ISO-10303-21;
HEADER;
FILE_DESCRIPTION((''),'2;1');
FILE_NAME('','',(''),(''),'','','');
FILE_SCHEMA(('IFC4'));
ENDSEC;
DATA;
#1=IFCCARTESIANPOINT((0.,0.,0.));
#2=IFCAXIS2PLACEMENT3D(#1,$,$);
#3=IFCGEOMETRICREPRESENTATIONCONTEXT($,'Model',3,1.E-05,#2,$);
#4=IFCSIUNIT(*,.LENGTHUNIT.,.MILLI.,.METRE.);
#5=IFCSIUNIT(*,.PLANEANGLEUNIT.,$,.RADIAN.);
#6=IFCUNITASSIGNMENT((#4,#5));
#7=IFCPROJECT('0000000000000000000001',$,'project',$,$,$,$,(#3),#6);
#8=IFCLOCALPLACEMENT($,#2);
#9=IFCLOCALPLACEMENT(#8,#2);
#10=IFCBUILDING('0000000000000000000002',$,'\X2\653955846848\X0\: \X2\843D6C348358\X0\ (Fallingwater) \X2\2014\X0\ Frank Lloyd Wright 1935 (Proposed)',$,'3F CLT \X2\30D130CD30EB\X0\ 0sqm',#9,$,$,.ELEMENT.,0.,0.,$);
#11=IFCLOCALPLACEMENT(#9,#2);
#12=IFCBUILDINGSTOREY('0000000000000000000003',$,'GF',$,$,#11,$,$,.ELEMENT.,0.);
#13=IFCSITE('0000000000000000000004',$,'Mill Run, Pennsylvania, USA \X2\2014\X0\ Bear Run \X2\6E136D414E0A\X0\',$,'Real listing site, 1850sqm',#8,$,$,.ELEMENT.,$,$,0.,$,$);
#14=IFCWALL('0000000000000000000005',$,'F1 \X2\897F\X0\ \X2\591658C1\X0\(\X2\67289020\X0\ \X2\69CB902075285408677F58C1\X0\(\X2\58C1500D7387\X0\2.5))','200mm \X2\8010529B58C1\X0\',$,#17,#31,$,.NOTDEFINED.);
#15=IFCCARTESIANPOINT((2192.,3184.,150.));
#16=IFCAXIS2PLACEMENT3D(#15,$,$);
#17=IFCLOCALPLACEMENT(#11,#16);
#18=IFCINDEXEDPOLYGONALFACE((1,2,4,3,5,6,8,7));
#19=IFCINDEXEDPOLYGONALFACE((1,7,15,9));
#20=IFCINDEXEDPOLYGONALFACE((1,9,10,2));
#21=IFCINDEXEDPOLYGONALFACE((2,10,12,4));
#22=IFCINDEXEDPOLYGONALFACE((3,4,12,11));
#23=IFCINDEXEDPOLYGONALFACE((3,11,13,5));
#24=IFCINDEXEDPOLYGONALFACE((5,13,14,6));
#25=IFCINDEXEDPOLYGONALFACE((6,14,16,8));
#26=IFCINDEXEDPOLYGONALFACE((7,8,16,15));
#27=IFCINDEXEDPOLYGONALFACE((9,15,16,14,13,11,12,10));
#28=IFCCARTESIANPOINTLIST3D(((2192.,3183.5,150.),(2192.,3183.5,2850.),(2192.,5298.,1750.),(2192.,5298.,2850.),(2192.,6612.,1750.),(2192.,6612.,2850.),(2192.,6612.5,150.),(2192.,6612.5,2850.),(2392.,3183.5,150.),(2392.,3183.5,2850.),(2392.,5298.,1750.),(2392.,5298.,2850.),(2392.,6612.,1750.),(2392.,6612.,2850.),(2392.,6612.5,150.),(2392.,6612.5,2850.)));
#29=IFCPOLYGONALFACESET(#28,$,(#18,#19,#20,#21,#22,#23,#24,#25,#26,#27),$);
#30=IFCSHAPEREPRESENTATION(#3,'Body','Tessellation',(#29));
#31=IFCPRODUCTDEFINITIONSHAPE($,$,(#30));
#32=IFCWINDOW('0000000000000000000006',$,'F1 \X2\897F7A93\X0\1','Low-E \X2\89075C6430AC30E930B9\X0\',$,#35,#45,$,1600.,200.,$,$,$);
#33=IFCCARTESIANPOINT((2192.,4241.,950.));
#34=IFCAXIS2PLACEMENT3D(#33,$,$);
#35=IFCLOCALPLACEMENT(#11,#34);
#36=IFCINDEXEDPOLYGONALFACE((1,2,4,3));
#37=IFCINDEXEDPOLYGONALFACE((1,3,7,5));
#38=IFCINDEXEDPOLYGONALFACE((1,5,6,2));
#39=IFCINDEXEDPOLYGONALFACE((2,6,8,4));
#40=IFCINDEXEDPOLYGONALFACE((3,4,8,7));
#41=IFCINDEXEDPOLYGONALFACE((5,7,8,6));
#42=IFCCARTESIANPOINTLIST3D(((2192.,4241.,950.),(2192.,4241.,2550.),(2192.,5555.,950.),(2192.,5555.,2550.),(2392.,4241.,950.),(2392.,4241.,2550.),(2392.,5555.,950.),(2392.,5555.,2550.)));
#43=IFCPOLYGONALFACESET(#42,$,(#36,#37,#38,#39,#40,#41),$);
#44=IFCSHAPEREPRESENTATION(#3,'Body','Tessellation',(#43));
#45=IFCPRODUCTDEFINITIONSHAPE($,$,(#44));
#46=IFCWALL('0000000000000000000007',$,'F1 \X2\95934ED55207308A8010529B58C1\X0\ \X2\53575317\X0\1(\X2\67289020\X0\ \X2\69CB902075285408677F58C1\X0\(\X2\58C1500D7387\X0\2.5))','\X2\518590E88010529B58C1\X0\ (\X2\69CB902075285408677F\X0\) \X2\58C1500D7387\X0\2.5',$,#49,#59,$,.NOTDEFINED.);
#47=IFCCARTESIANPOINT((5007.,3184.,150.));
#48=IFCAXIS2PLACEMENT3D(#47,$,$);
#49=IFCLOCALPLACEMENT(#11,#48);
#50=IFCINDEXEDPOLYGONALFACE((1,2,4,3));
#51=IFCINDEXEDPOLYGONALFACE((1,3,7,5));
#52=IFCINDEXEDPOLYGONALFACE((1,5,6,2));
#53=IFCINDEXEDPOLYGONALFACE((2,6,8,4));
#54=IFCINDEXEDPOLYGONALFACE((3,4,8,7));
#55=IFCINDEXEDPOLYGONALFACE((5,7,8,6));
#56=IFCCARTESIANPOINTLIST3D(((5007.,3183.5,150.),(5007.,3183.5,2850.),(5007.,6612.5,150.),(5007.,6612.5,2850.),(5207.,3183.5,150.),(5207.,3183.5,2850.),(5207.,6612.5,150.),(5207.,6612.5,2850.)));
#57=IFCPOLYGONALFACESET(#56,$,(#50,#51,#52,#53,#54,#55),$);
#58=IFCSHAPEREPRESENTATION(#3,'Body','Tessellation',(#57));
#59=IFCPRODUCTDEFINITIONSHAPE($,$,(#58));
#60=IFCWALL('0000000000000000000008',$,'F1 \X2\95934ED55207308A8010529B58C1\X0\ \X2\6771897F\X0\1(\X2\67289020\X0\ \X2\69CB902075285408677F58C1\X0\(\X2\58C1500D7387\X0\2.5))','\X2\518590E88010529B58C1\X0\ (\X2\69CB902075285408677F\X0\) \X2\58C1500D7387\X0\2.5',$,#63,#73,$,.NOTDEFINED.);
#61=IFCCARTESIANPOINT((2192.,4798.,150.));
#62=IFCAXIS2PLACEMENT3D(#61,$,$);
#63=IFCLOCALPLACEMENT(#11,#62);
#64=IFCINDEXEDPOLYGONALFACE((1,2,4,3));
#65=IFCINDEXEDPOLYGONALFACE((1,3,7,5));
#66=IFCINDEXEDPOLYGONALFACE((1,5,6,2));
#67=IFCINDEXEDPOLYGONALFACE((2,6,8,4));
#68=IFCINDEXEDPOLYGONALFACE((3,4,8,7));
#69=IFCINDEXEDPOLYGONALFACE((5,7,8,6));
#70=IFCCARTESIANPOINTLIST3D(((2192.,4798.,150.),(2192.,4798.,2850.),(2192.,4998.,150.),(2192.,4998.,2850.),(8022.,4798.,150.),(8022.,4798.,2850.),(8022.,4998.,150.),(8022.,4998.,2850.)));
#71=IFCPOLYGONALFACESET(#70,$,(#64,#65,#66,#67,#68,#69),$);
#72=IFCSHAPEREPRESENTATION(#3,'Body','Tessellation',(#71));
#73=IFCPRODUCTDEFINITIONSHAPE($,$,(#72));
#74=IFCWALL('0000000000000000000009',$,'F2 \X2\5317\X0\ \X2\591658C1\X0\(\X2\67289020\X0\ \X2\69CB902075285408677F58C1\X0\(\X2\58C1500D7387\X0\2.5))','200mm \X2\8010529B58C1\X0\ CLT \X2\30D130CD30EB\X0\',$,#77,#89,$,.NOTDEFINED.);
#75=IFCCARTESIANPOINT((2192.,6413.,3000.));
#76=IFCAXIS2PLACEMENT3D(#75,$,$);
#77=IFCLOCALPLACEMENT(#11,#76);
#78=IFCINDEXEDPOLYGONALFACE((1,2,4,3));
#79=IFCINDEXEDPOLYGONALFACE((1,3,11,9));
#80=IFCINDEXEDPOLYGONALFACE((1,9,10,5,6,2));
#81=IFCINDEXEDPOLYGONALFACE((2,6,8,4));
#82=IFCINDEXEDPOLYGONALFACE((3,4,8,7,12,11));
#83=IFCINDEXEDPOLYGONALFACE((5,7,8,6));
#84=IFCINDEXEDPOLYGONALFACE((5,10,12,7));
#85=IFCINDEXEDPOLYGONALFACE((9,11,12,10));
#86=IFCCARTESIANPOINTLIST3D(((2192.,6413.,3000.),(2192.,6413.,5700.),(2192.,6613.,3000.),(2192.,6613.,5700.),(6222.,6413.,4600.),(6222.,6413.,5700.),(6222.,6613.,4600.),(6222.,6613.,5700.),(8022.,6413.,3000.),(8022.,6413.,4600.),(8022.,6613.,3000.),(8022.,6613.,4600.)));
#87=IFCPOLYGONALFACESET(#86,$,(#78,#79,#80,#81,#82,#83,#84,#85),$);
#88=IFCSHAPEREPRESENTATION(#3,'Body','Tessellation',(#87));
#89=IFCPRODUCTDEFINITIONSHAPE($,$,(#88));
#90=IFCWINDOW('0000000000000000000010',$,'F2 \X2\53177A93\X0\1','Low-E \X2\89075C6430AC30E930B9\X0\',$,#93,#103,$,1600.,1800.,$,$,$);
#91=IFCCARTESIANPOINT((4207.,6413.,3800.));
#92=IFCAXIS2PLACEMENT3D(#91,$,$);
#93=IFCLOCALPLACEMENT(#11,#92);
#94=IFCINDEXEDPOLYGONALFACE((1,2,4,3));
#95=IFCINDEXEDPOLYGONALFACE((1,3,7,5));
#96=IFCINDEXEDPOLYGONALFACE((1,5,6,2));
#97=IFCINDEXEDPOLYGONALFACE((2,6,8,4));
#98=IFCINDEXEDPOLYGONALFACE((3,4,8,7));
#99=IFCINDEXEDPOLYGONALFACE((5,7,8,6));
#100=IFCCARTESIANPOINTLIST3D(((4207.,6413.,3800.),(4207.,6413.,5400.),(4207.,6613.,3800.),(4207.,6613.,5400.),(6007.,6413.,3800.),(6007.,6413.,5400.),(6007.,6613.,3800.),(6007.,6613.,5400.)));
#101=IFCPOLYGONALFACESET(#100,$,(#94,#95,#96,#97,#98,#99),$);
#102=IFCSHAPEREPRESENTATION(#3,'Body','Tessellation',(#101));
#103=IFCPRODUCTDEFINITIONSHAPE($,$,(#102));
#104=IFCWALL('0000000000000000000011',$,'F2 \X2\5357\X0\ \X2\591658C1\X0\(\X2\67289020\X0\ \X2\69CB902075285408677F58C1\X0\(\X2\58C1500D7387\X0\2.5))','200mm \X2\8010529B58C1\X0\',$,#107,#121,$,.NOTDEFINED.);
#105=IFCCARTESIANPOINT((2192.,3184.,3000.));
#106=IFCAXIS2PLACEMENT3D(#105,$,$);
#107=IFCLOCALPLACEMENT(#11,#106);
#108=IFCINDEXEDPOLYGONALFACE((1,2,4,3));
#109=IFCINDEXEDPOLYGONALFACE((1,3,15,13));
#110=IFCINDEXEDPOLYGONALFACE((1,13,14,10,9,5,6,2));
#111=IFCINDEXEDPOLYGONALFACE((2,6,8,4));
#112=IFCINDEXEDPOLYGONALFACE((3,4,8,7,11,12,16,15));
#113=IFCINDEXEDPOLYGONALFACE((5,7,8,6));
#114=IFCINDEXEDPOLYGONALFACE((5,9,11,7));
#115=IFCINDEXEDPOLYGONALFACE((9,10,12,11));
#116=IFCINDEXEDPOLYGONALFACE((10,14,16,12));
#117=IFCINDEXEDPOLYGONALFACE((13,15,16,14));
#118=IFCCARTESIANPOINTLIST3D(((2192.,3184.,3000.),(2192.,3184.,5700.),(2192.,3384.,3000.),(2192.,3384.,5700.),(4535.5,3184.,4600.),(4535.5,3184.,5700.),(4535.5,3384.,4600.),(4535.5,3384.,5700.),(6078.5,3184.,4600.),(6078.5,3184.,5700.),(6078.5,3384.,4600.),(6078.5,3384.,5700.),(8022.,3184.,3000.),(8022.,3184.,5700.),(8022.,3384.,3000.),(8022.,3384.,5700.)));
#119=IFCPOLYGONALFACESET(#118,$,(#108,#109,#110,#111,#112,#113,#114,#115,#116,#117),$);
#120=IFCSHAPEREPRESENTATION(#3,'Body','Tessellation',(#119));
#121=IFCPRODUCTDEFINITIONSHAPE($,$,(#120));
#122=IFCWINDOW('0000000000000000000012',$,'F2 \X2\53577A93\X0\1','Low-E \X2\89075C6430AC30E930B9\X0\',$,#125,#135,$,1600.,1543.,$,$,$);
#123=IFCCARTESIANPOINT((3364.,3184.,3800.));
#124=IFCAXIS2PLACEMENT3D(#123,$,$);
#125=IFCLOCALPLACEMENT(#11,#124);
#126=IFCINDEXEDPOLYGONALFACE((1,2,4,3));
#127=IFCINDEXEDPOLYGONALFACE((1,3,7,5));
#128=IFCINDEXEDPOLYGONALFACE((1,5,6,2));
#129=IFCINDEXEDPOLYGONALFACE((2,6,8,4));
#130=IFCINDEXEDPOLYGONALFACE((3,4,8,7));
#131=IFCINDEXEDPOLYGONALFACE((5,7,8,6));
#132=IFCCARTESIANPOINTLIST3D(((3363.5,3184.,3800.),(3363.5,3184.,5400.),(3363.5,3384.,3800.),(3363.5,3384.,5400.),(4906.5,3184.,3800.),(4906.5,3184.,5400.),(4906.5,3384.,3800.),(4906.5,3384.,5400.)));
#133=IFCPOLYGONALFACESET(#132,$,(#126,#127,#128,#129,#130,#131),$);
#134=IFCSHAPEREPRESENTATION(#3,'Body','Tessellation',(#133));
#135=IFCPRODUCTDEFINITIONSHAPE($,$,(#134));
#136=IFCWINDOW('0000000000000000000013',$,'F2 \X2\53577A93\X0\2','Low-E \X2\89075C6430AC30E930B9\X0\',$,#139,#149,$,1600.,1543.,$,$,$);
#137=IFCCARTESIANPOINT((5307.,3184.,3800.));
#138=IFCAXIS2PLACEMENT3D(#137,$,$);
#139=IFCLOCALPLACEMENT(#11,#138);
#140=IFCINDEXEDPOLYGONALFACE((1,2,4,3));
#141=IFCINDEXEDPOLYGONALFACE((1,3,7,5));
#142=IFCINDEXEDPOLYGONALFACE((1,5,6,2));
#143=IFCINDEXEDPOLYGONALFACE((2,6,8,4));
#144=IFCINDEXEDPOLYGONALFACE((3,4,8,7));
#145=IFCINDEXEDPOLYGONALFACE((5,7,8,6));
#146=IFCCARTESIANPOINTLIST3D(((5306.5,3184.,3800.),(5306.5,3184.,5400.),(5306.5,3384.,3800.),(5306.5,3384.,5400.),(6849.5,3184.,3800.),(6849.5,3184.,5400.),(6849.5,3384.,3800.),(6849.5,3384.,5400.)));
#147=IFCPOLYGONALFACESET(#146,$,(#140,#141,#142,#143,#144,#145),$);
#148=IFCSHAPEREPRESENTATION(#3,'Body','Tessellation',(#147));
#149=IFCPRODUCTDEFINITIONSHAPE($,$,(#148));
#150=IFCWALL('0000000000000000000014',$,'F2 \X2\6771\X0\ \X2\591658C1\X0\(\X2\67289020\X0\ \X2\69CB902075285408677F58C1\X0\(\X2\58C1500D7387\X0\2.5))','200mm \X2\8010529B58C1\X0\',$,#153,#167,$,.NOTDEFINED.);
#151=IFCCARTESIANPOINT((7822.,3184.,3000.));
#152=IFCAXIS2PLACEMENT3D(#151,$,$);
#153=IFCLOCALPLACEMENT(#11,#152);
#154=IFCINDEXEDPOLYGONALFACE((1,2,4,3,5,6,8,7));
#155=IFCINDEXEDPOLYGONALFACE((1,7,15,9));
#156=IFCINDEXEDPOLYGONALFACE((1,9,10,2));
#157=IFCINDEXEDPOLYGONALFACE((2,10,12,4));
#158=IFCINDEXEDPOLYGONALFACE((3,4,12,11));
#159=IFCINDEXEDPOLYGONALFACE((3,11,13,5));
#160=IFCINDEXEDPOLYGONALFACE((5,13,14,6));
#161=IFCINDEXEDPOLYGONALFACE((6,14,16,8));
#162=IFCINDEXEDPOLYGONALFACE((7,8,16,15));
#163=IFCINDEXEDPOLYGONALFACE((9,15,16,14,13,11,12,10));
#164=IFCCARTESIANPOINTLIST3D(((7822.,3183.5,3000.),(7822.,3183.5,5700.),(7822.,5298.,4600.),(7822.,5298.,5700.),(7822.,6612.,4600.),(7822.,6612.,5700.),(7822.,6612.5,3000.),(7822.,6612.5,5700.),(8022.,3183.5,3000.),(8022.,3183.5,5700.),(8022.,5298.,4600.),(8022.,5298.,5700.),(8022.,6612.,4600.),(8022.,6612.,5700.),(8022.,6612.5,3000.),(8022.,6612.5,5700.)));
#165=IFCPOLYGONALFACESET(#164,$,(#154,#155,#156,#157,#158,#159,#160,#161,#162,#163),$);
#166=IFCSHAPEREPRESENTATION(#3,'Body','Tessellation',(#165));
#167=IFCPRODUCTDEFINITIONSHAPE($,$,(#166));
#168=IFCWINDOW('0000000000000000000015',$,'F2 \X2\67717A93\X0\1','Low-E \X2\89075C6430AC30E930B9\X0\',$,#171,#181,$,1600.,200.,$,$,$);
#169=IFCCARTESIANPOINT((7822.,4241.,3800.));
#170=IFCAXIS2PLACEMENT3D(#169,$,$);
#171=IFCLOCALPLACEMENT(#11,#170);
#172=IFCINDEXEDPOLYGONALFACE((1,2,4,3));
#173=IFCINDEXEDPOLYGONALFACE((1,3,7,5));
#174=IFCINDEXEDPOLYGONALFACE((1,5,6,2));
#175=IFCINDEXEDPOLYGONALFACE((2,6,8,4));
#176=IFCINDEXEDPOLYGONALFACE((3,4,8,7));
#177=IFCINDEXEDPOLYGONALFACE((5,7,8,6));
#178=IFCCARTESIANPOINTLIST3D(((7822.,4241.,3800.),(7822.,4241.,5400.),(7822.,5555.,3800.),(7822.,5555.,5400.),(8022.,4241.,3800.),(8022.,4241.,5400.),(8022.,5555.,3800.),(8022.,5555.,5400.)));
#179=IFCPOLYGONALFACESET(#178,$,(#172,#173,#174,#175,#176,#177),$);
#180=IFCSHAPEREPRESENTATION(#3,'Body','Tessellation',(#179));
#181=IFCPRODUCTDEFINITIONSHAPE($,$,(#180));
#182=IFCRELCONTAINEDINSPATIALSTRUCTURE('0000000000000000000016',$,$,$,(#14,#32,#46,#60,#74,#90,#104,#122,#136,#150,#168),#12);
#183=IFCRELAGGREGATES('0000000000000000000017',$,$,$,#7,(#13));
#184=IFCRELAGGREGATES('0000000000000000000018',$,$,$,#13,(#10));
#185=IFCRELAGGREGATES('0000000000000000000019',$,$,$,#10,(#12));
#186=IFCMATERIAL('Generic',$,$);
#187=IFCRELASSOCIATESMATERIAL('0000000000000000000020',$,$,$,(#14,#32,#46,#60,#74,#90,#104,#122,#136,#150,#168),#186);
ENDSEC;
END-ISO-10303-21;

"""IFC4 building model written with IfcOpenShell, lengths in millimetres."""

from ifc_helpers import new_model, si_unit, frame, frame_2d, origin, place, context, project, spatial, rectangle, extrude, material, element, fill, save


model = new_model("IFC4")

# Units and contexts
model_context = context("Model", 3, precision=1e-05, world=origin())
ifc_project = project(units=[si_unit("LENGTHUNIT", "METRE", prefix="MILLI"), si_unit("PLANEANGLEUNIT", "RADIAN")], contexts=[model_context])

# Site, building, storey
site_placement = place(None, origin())
site = spatial("IfcSite", under=ifc_project, at=site_placement, Name="Mill Run, Pennsylvania, USA — Bear Run 渓流上", ObjectType="Real listing site, 1850sqm", CompositionType="ELEMENT", RefElevation=0.0)
building_placement = place(site_placement, origin())
building = spatial("IfcBuilding", under=site, at=building_placement, Name="改善案: 落水荘 (Fallingwater) — Frank Lloyd Wright 1935 (Proposed)", ObjectType="3F CLT パネル 0sqm", CompositionType="ELEMENT", ElevationOfRefHeight=0.0, ElevationOfTerrain=0.0)
storey_placement = place(building_placement, origin())
storey = spatial("IfcBuildingStorey", under=building, at=storey_placement, Name="GF", CompositionType="ELEMENT", Elevation=0.0)

# Shared definitions
ifc_material_1 = material(Name="Generic")

# Wall, opening, window
wall_1_placement = place(storey_placement, frame((2192.0, 3184.0, 150.0)))
wall_1 = element("IfcWall", 1, at=wall_1_placement, inside=storey, material=ifc_material_1, Name="F1 西 外壁(木造 構造用合板壁(壁倍率2.5))", Description="200mm 耐力壁", PredefinedType="NOTDEFINED", context=model_context, shape_type="SweptSolid", body=[
    extrude(rectangle(XDim=200.0, YDim=3429.0, at=frame_2d((100.0, 1714.0))), frame((2192.0, 3184.0, 150.0)), (0.0, 0.0, 1.0), 2700.0),
])
opening_1_placement = place(storey_placement, frame((2192.0, 4241.0, 950.0)))
opening_1 = element("IfcOpeningElement", 2, at=opening_1_placement, cuts=wall_1, PredefinedType="NOTDEFINED", context=model_context, shape_type="SweptSolid", body=[
    extrude(rectangle(XDim=200.0, YDim=1314.0, at=frame_2d((100.0, 657.0))), frame((2192.0, 4241.0, 950.0)), (0.0, 0.0, 1.0), 1600.0),
])
window_1_placement = place(storey_placement, frame((2192.0, 4241.0, 950.0)))
window_1 = element("IfcWindow", 3, at=window_1_placement, inside=storey, material=ifc_material_1, Name="F1 西窓1", Description="Low-E 複層ガラス", OverallHeight=1600.0, OverallWidth=200.0, context=model_context, shape_type="SweptSolid", body=[
    extrude(rectangle(XDim=200.0, YDim=1314.0, at=frame_2d((100.0, 657.0))), frame((2192.0, 4241.0, 950.0)), (0.0, 0.0, 1.0), 1600.0),
])
fill(opening_1, window_1)

# Walls
wall_2_placement = place(storey_placement, frame((5007.0, 3184.0, 150.0)))
element("IfcWall", 4, at=wall_2_placement, inside=storey, material=ifc_material_1, Name="F1 間仕切り耐力壁 南北1(木造 構造用合板壁(壁倍率2.5))", Description="内部耐力壁 (構造用合板) 壁倍率2.5", PredefinedType="NOTDEFINED", context=model_context, shape_type="SweptSolid", body=[
    extrude(rectangle(XDim=200.0, YDim=3429.0, at=frame_2d((100.0, 1714.0))), frame((5007.0, 3184.0, 150.0)), (0.0, 0.0, 1.0), 2700.0),
])
wall_3_placement = place(storey_placement, frame((2192.0, 4798.0, 150.0)))
element("IfcWall", 5, at=wall_3_placement, inside=storey, material=ifc_material_1, Name="F1 間仕切り耐力壁 東西1(木造 構造用合板壁(壁倍率2.5))", Description="内部耐力壁 (構造用合板) 壁倍率2.5", PredefinedType="NOTDEFINED", context=model_context, shape_type="SweptSolid", body=[
    extrude(rectangle(XDim=5830.0, YDim=200.0, at=frame_2d((2915.0, 100.0))), frame((2192.0, 4798.0, 150.0)), (0.0, 0.0, 1.0), 2700.0),
])

# Wall, opening, window
wall_4_placement = place(storey_placement, frame((2192.0, 6413.0, 3000.0)))
wall_4 = element("IfcWall", 6, at=wall_4_placement, inside=storey, material=ifc_material_1, Name="F2 北 外壁(木造 構造用合板壁(壁倍率2.5))", Description="200mm 耐力壁 CLT パネル", PredefinedType="NOTDEFINED", context=model_context, shape_type="SweptSolid", body=[
    extrude(rectangle(XDim=5830.0, YDim=200.0, at=frame_2d((2915.0, 100.0))), frame((2192.0, 6413.0, 3000.0)), (0.0, 0.0, 1.0), 2700.0),
])
opening_2_placement = place(storey_placement, frame((4207.0, 6413.0, 3800.0)))
opening_2 = element("IfcOpeningElement", 7, at=opening_2_placement, cuts=wall_4, PredefinedType="NOTDEFINED", context=model_context, shape_type="SweptSolid", body=[
    extrude(rectangle(XDim=1800.0, YDim=200.0, at=frame_2d((900.0, 100.0))), frame((4207.0, 6413.0, 3800.0)), (0.0, 0.0, 1.0), 1600.0),
])
window_2_placement = place(storey_placement, frame((4207.0, 6413.0, 3800.0)))
window_2 = element("IfcWindow", 8, at=window_2_placement, inside=storey, material=ifc_material_1, Name="F2 北窓1", Description="Low-E 複層ガラス", OverallHeight=1600.0, OverallWidth=1800.0, context=model_context, shape_type="SweptSolid", body=[
    extrude(rectangle(XDim=1800.0, YDim=200.0, at=frame_2d((900.0, 100.0))), frame((4207.0, 6413.0, 3800.0)), (0.0, 0.0, 1.0), 1600.0),
])
fill(opening_2, window_2)

# Wall, openings, windows
wall_5_placement = place(storey_placement, frame((2192.0, 3184.0, 3000.0)))
wall_5 = element("IfcWall", 9, at=wall_5_placement, inside=storey, material=ifc_material_1, Name="F2 南 外壁(木造 構造用合板壁(壁倍率2.5))", Description="200mm 耐力壁", PredefinedType="NOTDEFINED", context=model_context, shape_type="SweptSolid", body=[
    extrude(rectangle(XDim=5830.0, YDim=200.0, at=frame_2d((2915.0, 100.0))), frame((2192.0, 3184.0, 3000.0)), (0.0, 0.0, 1.0), 2700.0),
])
opening_3_placement = place(storey_placement, frame((3364.0, 3184.0, 3800.0)))
opening_3 = element("IfcOpeningElement", 10, at=opening_3_placement, cuts=wall_5, PredefinedType="NOTDEFINED", context=model_context, shape_type="SweptSolid", body=[
    extrude(rectangle(XDim=1543.0, YDim=200.0, at=frame_2d((771.0, 100.0))), frame((3364.0, 3184.0, 3800.0)), (0.0, 0.0, 1.0), 1600.0),
])
opening_4_placement = place(storey_placement, frame((5307.0, 3184.0, 3800.0)))
opening_4 = element("IfcOpeningElement", 11, at=opening_4_placement, cuts=wall_5, PredefinedType="NOTDEFINED", context=model_context, shape_type="SweptSolid", body=[
    extrude(rectangle(XDim=1543.0, YDim=200.0, at=frame_2d((771.0, 100.0))), frame((5307.0, 3184.0, 3800.0)), (0.0, 0.0, 1.0), 1600.0),
])
window_3_placement = place(storey_placement, frame((3364.0, 3184.0, 3800.0)))
window_3 = element("IfcWindow", 12, at=window_3_placement, inside=storey, material=ifc_material_1, Name="F2 南窓1", Description="Low-E 複層ガラス", OverallHeight=1600.0, OverallWidth=1543.0, context=model_context, shape_type="SweptSolid", body=[
    extrude(rectangle(XDim=1543.0, YDim=200.0, at=frame_2d((771.0, 100.0))), frame((3364.0, 3184.0, 3800.0)), (0.0, 0.0, 1.0), 1600.0),
])
fill(opening_3, window_3)
window_4_placement = place(storey_placement, frame((5307.0, 3184.0, 3800.0)))
window_4 = element("IfcWindow", 13, at=window_4_placement, inside=storey, material=ifc_material_1, Name="F2 南窓2", Description="Low-E 複層ガラス", OverallHeight=1600.0, OverallWidth=1543.0, context=model_context, shape_type="SweptSolid", body=[
    extrude(rectangle(XDim=1543.0, YDim=200.0, at=frame_2d((771.0, 100.0))), frame((5307.0, 3184.0, 3800.0)), (0.0, 0.0, 1.0), 1600.0),
])
fill(opening_4, window_4)

# Wall, opening, window
wall_6_placement = place(storey_placement, frame((7822.0, 3184.0, 3000.0)))
wall_6 = element("IfcWall", 14, at=wall_6_placement, inside=storey, material=ifc_material_1, Name="F2 東 外壁(木造 構造用合板壁(壁倍率2.5))", Description="200mm 耐力壁", PredefinedType="NOTDEFINED", context=model_context, shape_type="SweptSolid", body=[
    extrude(rectangle(XDim=200.0, YDim=3429.0, at=frame_2d((100.0, 1714.0))), frame((7822.0, 3184.0, 3000.0)), (0.0, 0.0, 1.0), 2700.0),
])
opening_5_placement = place(storey_placement, frame((7822.0, 4241.0, 3800.0)))
opening_5 = element("IfcOpeningElement", 15, at=opening_5_placement, cuts=wall_6, PredefinedType="NOTDEFINED", context=model_context, shape_type="SweptSolid", body=[
    extrude(rectangle(XDim=200.0, YDim=1314.0, at=frame_2d((100.0, 657.0))), frame((7822.0, 4241.0, 3800.0)), (0.0, 0.0, 1.0), 1600.0),
])
window_5_placement = place(storey_placement, frame((7822.0, 4241.0, 3800.0)))
window_5 = element("IfcWindow", 16, at=window_5_placement, inside=storey, material=ifc_material_1, Name="F2 東窓1", Description="Low-E 複層ガラス", OverallHeight=1600.0, OverallWidth=200.0, context=model_context, shape_type="SweptSolid", body=[
    extrude(rectangle(XDim=200.0, YDim=1314.0, at=frame_2d((100.0, 657.0))), frame((7822.0, 4241.0, 3800.0)), (0.0, 0.0, 1.0), 1600.0),
])
fill(opening_5, window_5)

save(model, "model.ifc")
